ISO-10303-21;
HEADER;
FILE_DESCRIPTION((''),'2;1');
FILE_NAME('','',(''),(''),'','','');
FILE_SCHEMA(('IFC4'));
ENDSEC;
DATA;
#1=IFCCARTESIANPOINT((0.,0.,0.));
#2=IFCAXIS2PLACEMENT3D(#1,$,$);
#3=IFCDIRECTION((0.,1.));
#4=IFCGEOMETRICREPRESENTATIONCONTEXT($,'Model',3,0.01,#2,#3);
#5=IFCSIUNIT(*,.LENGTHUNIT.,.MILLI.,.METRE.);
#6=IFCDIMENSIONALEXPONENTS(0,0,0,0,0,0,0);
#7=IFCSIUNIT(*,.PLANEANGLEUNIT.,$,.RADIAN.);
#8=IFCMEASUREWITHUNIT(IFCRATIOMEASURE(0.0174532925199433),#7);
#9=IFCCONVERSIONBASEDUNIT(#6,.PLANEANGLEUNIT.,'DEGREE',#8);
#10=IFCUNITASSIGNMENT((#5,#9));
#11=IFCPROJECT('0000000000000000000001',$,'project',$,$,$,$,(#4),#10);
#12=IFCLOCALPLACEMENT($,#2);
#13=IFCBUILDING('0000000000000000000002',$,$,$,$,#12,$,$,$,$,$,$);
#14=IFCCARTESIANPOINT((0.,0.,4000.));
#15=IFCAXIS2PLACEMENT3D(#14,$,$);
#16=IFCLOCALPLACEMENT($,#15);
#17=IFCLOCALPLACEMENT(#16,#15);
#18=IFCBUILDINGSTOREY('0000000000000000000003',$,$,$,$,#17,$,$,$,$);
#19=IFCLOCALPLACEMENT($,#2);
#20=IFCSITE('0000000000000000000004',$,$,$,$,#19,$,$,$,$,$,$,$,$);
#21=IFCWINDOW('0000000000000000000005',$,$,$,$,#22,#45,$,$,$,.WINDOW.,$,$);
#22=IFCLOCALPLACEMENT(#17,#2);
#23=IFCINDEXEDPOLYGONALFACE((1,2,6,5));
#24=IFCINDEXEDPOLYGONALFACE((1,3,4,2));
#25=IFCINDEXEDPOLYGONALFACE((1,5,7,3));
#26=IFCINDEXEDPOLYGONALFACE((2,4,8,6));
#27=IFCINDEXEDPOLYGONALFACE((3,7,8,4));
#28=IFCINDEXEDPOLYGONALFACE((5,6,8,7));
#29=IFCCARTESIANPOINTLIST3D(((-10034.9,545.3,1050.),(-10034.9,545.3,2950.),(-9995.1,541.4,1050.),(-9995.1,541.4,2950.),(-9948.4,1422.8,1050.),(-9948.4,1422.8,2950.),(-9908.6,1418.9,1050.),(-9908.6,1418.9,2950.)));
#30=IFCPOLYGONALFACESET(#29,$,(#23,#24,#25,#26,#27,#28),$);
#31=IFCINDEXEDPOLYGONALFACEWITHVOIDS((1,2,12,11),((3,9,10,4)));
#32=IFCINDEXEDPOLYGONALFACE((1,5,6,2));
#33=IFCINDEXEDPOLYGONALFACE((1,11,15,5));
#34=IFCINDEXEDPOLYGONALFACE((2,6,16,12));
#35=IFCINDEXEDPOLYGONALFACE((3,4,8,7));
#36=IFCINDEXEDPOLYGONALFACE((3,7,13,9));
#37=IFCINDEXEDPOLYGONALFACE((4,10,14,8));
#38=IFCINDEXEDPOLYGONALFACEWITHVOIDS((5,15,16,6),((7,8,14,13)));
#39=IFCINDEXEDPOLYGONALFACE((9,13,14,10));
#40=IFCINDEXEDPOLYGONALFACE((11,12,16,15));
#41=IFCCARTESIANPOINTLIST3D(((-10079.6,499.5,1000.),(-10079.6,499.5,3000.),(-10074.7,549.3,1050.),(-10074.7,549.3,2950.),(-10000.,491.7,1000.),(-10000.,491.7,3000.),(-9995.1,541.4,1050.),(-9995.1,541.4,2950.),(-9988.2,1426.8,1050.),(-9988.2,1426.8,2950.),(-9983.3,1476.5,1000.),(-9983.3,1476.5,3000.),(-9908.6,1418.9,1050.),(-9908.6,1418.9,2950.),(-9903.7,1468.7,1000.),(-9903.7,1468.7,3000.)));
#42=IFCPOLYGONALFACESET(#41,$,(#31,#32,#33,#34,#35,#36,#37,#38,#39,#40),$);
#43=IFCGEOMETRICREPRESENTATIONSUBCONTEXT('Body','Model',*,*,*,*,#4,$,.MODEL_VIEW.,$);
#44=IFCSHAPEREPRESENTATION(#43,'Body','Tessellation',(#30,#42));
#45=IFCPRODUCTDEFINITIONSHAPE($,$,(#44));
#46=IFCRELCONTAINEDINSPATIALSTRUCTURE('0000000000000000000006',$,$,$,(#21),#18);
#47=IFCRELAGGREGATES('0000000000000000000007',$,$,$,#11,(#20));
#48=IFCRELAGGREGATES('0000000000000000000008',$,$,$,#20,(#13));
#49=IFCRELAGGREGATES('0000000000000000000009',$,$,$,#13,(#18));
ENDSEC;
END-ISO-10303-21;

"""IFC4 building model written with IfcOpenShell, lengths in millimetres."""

from ifc_helpers import new_model, entity, si_unit, converted_unit, direction, frame, origin, place, context, subcontext, project, spatial, element, save


model = new_model("IFC4")

# Units and contexts
model_context = context("Model", 3, precision=0.01, world=origin(), true_north=direction((0.0, 1.0)))
body_context = subcontext(model_context, "Body", "Model", "MODEL_VIEW")
ifc_project = project(units=[si_unit("LENGTHUNIT", "METRE", prefix="MILLI"), converted_unit("PLANEANGLEUNIT", "DEGREE", entity("IfcRatioMeasure", 0.0174532925199433), si_unit("PLANEANGLEUNIT", "RADIAN"), dimensions=[0, 0, 0, 0, 0, 0, 0])], contexts=[model_context])

# Site, building, storey
site_placement = place(None, origin())
site = spatial("IfcSite", under=ifc_project, at=site_placement)
building_placement = place(None, origin())
building = spatial("IfcBuilding", under=site, at=building_placement)
placement = place(None, frame((0.0, 0.0, 4000.0)))
storey_placement = place(placement, frame((0.0, 0.0, 4000.0)))
storey = spatial("IfcBuildingStorey", under=building, at=storey_placement)

# Shared definitions
cartesian_point_1 = entity("IfcCartesianPoint", [-440.9, -950.0])
shared_polyline = entity("IfcPolyline", [cartesian_point_1, entity("IfcCartesianPoint", [-440.9, 950.0]), entity("IfcCartesianPoint", [-440.9, 950.0]), entity("IfcCartesianPoint", [440.9, 950.0]), entity("IfcCartesianPoint", [440.9, 950.0]), entity("IfcCartesianPoint", [440.9, -950.0]), entity("IfcCartesianPoint", [440.9, -950.0]), entity("IfcCartesianPoint", [-440.9, -950.0]), cartesian_point_1])

# Window
window_1_placement = place(storey_placement, frame((-9951.8, 980.2, 2000.0), z_axis=(0.0, 0.0, 1.0), x_axis=(-980.170931, -9951.847313, 0.0)))
cartesian_point_2 = entity("IfcCartesianPoint", [-490.9, -1000.0])
element("IfcWindow", 1, at=window_1_placement, inside=storey, PredefinedType="WINDOW", context=body_context, shape_type="SweptSolid", body=[
    entity("IfcExtrudedAreaSolid", entity("IfcArbitraryClosedProfileDef", "AREA", None, shared_polyline), entity("IfcAxis2Placement3D", entity("IfcCartesianPoint", [0.0, 0.0, 0.0]), entity("IfcDirection", [0.0, -1.0, 0.0]), entity("IfcDirection", [1.0, 0.0, 0.0])), entity("IfcDirection", [0.0, 0.0, 1.0]), 40.0),
    entity("IfcExtrudedAreaSolid", entity("IfcArbitraryProfileDefWithVoids", "AREA", None, entity("IfcPolyline", [cartesian_point_2, entity("IfcCartesianPoint", [-490.9, 1000.0]), entity("IfcCartesianPoint", [-490.9, 1000.0]), entity("IfcCartesianPoint", [490.9, 1000.0]), entity("IfcCartesianPoint", [490.9, 1000.0]), entity("IfcCartesianPoint", [490.9, -1000.0]), entity("IfcCartesianPoint", [490.9, -1000.0]), entity("IfcCartesianPoint", [-490.9, -1000.0]), cartesian_point_2]), [shared_polyline]), entity("IfcAxis2Placement3D", entity("IfcCartesianPoint", [0.0, 0.0, 0.0]), entity("IfcDirection", [0.0, -1.0, 0.0]), entity("IfcDirection", [1.0, 0.0, 0.0])), entity("IfcDirection", [0.0, 0.0, 1.0]), 80.0),
])

save(model, "model.ifc")
